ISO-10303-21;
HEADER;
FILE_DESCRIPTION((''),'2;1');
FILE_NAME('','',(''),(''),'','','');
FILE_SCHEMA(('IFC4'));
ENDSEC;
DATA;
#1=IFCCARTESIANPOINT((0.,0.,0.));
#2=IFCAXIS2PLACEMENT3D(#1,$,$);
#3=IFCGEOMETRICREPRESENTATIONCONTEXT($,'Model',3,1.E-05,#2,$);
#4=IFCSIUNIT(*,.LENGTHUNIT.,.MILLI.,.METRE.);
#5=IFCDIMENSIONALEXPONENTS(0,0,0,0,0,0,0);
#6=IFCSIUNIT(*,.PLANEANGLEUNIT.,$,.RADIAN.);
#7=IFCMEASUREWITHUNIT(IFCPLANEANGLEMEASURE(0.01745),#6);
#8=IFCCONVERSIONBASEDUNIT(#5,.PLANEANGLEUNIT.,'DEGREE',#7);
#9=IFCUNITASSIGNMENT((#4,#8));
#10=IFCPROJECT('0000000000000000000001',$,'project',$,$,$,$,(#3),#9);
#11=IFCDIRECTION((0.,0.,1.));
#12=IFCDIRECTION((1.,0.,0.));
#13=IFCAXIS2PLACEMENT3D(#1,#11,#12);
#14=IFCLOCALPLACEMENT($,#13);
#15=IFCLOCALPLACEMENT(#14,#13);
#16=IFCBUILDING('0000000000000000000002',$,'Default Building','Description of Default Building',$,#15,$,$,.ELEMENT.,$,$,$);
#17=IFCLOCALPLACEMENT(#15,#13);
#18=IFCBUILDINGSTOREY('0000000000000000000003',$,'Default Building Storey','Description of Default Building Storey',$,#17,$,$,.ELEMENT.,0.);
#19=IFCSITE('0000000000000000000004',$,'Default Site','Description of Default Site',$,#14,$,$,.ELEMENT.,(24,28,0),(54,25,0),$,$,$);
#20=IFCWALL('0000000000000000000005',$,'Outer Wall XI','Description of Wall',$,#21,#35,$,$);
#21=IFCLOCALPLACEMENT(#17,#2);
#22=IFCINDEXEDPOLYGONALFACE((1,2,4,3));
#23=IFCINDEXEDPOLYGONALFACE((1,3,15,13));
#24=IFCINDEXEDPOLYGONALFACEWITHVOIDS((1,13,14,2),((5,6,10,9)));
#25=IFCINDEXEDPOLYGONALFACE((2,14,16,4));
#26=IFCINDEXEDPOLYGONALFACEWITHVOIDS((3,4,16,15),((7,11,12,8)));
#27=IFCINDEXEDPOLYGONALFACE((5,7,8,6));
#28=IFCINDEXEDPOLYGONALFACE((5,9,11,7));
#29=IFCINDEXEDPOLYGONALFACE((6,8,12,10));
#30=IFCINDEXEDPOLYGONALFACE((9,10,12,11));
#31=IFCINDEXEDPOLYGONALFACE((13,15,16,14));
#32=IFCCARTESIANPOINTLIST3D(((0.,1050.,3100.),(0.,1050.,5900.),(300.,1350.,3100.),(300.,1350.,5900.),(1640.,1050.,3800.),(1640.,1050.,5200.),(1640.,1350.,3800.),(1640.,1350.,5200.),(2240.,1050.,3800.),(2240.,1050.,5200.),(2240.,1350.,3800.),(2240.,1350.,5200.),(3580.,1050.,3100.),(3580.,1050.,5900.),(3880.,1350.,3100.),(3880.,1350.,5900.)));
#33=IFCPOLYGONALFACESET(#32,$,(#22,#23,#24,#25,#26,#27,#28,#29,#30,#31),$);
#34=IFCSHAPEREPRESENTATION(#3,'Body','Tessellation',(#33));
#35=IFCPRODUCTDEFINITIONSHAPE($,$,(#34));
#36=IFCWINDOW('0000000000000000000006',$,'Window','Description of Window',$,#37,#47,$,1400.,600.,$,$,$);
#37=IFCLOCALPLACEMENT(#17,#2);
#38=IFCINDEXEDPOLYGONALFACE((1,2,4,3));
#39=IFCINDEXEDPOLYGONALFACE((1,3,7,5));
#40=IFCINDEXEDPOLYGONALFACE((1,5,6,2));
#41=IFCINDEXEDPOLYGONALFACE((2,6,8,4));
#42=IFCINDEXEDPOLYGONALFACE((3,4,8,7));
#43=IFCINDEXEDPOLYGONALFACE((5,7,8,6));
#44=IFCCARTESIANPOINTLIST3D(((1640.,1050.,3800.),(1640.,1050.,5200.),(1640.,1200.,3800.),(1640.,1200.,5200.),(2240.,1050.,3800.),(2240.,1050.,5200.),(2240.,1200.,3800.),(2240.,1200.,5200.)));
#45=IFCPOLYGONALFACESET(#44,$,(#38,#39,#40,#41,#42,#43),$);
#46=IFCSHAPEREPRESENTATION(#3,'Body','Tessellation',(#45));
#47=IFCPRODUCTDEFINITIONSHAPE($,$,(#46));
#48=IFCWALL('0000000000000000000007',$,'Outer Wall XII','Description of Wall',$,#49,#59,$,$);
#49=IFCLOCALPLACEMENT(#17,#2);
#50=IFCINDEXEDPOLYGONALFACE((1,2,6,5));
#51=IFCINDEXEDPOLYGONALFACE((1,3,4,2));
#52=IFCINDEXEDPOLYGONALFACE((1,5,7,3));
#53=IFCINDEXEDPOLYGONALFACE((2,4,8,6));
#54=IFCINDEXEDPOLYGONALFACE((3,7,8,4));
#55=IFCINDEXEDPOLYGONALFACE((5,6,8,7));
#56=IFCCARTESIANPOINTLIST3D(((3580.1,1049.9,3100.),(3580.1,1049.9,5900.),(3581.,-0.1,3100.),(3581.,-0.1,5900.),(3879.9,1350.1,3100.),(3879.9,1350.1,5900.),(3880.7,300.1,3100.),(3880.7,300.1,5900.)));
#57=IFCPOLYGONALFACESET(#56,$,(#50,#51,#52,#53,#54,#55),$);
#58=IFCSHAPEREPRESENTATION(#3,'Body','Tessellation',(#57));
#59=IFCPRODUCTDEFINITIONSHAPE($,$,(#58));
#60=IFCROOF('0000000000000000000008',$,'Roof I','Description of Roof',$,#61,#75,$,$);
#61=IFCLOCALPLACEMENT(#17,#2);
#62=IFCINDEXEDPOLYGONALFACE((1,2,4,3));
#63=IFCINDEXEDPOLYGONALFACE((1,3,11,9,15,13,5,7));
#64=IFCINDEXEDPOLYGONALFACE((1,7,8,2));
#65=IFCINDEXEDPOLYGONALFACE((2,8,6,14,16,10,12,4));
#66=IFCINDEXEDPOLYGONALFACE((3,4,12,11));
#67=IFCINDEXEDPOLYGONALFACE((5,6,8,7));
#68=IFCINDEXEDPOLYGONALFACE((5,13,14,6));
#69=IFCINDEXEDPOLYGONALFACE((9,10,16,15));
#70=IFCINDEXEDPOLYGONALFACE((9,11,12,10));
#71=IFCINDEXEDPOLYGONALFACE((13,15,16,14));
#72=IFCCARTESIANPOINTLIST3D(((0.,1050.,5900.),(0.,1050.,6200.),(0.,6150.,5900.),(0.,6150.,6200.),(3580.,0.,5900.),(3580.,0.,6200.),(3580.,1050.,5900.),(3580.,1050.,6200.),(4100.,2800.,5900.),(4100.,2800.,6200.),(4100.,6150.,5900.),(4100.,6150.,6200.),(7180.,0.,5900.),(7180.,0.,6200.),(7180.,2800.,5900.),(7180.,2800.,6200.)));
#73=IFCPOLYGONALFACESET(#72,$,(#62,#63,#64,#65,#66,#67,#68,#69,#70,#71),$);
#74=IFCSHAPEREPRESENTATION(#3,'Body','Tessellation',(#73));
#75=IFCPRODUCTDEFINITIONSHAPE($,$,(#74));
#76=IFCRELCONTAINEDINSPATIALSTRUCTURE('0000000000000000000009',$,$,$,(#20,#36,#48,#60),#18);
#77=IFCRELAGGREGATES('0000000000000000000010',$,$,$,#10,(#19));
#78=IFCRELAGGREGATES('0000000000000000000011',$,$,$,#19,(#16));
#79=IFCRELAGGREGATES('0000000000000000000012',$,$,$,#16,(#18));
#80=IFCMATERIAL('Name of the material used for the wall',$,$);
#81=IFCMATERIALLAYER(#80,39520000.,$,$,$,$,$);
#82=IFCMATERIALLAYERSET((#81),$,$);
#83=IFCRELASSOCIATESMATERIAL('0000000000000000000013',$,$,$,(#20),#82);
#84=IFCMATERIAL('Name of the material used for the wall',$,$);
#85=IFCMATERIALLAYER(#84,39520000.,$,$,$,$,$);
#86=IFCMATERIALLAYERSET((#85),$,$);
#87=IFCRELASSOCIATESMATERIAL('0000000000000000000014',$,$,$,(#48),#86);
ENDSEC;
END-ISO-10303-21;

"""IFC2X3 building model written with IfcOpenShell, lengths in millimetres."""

from ifc_helpers import new_model, entity, si_unit, converted_unit, frame, origin, origin_with_axes, place, context, project, spatial, polyline, outline, extrude, material, layer, layer_set, layer_usage, element, fill, save


model = new_model("IFC2X3")

# Units and contexts
model_context = context("Model", 3, precision=1e-05, world=origin())
ifc_project = project(units=[si_unit("LENGTHUNIT", "METRE", prefix="MILLI"), converted_unit("PLANEANGLEUNIT", "DEGREE", entity("IfcPlaneAngleMeasure", 0.01745), si_unit("PLANEANGLEUNIT", "RADIAN"), dimensions=[0, 0, 0, 0, 0, 0, 0])], contexts=[model_context])

# Site, building, storey
site_placement = place(None, origin_with_axes())
site = spatial("IfcSite", under=ifc_project, at=site_placement, Name="Default Site", Description="Description of Default Site", CompositionType="ELEMENT", RefLatitude=(24, 28, 0), RefLongitude=(54, 25, 0))
building_placement = place(site_placement, origin_with_axes())
building = spatial("IfcBuilding", under=site, at=building_placement, Name="Default Building", Description="Description of Default Building", CompositionType="ELEMENT")
storey_placement = place(building_placement, origin_with_axes())
storey = spatial("IfcBuildingStorey", under=building, at=storey_placement, Name="Default Building Storey", Description="Description of Default Building Storey", CompositionType="ELEMENT", Elevation=0.0)

# Wall, opening, window
ifc_material_1 = material(Name="Name of the material used for the wall")
ifc_layer_1 = layer(ifc_material_1, 39520000.0)
ifc_layer_set_1 = layer_set([ifc_layer_1])
ifc_layer_usage_1 = layer_usage(ifc_layer_set_1, "AXIS2", "POSITIVE", -19760000.0)
wall_1_placement = place(storey_placement, frame((150.0, 1200.0, 3100.0), z_axis=(0.0, 0.0, 1.0), x_axis=(1.0, 0.0, 0.0)))
wall_1 = element("IfcWall", 1, at=wall_1_placement, inside=storey, material=ifc_layer_usage_1, Name="Outer Wall XI", Description="Description of Wall", context=model_context, shape_type="SweptSolid", body=[
    extrude(outline(polyline([(-150.0, -150.0), (150.0, 150.0), (3730.0, 150.0), (3430.0, -150.0), (-150.0, -150.0)])), origin_with_axes(), (0.0, 0.0, 1.0), 2800.0),
])
opening_1_placement = place(wall_1_placement, frame((1490.0, -150.0, 700.0), z_axis=(0.0, 0.0, 1.0), x_axis=(1.0, 0.0, 0.0)))
opening_1 = element("IfcOpeningElement", 2, at=opening_1_placement, cuts=wall_1, context=model_context, shape_type="SweptSolid", body=[
    extrude(outline(polyline([(0.0, 0.0), (0.0, 300.0), (600.0, 300.0), (600.0, 0.0), (0.0, 0.0)])), origin_with_axes(), (0.0, 0.0, 1.0), 1400.0),
])
window_1_placement = place(opening_1_placement, origin_with_axes())
window_1 = element("IfcWindow", 3, at=window_1_placement, inside=storey, Name="Window", Description="Description of Window", OverallHeight=1400.0, OverallWidth=600.0, context=model_context, shape_type="SweptSolid", body=[
    extrude(outline(polyline([(0.0, 0.0), (0.0, 150.0), (600.0, 150.0), (600.0, 0.0), (0.0, 0.0)])), origin_with_axes(), (0.0, 0.0, 1.0), 1400.0),
])
fill(opening_1, window_1)

# Wall
ifc_material_2 = material(Name="Name of the material used for the wall")
ifc_layer_2 = layer(ifc_material_2, 39520000.0)
ifc_layer_set_2 = layer_set([ifc_layer_2])
ifc_layer_usage_2 = layer_usage(ifc_layer_set_2, "AXIS2", "POSITIVE", -19760000.0)
wall_2_placement = place(storey_placement, frame((3730.0, 1200.0, 3100.0), z_axis=(0.0, 0.0, 1.0), x_axis=(0.000796, -1.0, 0.0)))
element("IfcWall", 4, at=wall_2_placement, inside=storey, material=ifc_layer_usage_2, Name="Outer Wall XII", Description="Description of Wall", context=model_context, shape_type="SweptSolid", body=[
    extrude(outline(polyline([(150.0, -150.0), (-150.0, 150.0), (900.0, 150.0), (1200.0, -150.0), (150.0, -150.0)])), origin_with_axes(), (0.0, 0.0, 1.0), 2800.0),
])

# Roof
roof_placement = place(storey_placement, frame((0.0, 0.0, 5900.0), z_axis=(0.0, 0.0, 1.0), x_axis=(1.0, 0.0, 0.0)))
element("IfcRoof", 5, at=roof_placement, inside=storey, Name="Roof I", Description="Description of Roof", context=model_context, shape_type="SweptSolid", body=[
    extrude(outline(polyline([(0.0, 1050.0), (0.0, 6150.0), (4100.0, 6150.0), (4100.0, 2800.0), (7180.0, 2800.0), (7180.0, 0.0), (3580.0, 0.0), (3580.0, 1050.0), (0.0, 1050.0)])), origin_with_axes(), (0.0, 0.0, 1.0), 300.0),
])

save(model, "model.ifc")
